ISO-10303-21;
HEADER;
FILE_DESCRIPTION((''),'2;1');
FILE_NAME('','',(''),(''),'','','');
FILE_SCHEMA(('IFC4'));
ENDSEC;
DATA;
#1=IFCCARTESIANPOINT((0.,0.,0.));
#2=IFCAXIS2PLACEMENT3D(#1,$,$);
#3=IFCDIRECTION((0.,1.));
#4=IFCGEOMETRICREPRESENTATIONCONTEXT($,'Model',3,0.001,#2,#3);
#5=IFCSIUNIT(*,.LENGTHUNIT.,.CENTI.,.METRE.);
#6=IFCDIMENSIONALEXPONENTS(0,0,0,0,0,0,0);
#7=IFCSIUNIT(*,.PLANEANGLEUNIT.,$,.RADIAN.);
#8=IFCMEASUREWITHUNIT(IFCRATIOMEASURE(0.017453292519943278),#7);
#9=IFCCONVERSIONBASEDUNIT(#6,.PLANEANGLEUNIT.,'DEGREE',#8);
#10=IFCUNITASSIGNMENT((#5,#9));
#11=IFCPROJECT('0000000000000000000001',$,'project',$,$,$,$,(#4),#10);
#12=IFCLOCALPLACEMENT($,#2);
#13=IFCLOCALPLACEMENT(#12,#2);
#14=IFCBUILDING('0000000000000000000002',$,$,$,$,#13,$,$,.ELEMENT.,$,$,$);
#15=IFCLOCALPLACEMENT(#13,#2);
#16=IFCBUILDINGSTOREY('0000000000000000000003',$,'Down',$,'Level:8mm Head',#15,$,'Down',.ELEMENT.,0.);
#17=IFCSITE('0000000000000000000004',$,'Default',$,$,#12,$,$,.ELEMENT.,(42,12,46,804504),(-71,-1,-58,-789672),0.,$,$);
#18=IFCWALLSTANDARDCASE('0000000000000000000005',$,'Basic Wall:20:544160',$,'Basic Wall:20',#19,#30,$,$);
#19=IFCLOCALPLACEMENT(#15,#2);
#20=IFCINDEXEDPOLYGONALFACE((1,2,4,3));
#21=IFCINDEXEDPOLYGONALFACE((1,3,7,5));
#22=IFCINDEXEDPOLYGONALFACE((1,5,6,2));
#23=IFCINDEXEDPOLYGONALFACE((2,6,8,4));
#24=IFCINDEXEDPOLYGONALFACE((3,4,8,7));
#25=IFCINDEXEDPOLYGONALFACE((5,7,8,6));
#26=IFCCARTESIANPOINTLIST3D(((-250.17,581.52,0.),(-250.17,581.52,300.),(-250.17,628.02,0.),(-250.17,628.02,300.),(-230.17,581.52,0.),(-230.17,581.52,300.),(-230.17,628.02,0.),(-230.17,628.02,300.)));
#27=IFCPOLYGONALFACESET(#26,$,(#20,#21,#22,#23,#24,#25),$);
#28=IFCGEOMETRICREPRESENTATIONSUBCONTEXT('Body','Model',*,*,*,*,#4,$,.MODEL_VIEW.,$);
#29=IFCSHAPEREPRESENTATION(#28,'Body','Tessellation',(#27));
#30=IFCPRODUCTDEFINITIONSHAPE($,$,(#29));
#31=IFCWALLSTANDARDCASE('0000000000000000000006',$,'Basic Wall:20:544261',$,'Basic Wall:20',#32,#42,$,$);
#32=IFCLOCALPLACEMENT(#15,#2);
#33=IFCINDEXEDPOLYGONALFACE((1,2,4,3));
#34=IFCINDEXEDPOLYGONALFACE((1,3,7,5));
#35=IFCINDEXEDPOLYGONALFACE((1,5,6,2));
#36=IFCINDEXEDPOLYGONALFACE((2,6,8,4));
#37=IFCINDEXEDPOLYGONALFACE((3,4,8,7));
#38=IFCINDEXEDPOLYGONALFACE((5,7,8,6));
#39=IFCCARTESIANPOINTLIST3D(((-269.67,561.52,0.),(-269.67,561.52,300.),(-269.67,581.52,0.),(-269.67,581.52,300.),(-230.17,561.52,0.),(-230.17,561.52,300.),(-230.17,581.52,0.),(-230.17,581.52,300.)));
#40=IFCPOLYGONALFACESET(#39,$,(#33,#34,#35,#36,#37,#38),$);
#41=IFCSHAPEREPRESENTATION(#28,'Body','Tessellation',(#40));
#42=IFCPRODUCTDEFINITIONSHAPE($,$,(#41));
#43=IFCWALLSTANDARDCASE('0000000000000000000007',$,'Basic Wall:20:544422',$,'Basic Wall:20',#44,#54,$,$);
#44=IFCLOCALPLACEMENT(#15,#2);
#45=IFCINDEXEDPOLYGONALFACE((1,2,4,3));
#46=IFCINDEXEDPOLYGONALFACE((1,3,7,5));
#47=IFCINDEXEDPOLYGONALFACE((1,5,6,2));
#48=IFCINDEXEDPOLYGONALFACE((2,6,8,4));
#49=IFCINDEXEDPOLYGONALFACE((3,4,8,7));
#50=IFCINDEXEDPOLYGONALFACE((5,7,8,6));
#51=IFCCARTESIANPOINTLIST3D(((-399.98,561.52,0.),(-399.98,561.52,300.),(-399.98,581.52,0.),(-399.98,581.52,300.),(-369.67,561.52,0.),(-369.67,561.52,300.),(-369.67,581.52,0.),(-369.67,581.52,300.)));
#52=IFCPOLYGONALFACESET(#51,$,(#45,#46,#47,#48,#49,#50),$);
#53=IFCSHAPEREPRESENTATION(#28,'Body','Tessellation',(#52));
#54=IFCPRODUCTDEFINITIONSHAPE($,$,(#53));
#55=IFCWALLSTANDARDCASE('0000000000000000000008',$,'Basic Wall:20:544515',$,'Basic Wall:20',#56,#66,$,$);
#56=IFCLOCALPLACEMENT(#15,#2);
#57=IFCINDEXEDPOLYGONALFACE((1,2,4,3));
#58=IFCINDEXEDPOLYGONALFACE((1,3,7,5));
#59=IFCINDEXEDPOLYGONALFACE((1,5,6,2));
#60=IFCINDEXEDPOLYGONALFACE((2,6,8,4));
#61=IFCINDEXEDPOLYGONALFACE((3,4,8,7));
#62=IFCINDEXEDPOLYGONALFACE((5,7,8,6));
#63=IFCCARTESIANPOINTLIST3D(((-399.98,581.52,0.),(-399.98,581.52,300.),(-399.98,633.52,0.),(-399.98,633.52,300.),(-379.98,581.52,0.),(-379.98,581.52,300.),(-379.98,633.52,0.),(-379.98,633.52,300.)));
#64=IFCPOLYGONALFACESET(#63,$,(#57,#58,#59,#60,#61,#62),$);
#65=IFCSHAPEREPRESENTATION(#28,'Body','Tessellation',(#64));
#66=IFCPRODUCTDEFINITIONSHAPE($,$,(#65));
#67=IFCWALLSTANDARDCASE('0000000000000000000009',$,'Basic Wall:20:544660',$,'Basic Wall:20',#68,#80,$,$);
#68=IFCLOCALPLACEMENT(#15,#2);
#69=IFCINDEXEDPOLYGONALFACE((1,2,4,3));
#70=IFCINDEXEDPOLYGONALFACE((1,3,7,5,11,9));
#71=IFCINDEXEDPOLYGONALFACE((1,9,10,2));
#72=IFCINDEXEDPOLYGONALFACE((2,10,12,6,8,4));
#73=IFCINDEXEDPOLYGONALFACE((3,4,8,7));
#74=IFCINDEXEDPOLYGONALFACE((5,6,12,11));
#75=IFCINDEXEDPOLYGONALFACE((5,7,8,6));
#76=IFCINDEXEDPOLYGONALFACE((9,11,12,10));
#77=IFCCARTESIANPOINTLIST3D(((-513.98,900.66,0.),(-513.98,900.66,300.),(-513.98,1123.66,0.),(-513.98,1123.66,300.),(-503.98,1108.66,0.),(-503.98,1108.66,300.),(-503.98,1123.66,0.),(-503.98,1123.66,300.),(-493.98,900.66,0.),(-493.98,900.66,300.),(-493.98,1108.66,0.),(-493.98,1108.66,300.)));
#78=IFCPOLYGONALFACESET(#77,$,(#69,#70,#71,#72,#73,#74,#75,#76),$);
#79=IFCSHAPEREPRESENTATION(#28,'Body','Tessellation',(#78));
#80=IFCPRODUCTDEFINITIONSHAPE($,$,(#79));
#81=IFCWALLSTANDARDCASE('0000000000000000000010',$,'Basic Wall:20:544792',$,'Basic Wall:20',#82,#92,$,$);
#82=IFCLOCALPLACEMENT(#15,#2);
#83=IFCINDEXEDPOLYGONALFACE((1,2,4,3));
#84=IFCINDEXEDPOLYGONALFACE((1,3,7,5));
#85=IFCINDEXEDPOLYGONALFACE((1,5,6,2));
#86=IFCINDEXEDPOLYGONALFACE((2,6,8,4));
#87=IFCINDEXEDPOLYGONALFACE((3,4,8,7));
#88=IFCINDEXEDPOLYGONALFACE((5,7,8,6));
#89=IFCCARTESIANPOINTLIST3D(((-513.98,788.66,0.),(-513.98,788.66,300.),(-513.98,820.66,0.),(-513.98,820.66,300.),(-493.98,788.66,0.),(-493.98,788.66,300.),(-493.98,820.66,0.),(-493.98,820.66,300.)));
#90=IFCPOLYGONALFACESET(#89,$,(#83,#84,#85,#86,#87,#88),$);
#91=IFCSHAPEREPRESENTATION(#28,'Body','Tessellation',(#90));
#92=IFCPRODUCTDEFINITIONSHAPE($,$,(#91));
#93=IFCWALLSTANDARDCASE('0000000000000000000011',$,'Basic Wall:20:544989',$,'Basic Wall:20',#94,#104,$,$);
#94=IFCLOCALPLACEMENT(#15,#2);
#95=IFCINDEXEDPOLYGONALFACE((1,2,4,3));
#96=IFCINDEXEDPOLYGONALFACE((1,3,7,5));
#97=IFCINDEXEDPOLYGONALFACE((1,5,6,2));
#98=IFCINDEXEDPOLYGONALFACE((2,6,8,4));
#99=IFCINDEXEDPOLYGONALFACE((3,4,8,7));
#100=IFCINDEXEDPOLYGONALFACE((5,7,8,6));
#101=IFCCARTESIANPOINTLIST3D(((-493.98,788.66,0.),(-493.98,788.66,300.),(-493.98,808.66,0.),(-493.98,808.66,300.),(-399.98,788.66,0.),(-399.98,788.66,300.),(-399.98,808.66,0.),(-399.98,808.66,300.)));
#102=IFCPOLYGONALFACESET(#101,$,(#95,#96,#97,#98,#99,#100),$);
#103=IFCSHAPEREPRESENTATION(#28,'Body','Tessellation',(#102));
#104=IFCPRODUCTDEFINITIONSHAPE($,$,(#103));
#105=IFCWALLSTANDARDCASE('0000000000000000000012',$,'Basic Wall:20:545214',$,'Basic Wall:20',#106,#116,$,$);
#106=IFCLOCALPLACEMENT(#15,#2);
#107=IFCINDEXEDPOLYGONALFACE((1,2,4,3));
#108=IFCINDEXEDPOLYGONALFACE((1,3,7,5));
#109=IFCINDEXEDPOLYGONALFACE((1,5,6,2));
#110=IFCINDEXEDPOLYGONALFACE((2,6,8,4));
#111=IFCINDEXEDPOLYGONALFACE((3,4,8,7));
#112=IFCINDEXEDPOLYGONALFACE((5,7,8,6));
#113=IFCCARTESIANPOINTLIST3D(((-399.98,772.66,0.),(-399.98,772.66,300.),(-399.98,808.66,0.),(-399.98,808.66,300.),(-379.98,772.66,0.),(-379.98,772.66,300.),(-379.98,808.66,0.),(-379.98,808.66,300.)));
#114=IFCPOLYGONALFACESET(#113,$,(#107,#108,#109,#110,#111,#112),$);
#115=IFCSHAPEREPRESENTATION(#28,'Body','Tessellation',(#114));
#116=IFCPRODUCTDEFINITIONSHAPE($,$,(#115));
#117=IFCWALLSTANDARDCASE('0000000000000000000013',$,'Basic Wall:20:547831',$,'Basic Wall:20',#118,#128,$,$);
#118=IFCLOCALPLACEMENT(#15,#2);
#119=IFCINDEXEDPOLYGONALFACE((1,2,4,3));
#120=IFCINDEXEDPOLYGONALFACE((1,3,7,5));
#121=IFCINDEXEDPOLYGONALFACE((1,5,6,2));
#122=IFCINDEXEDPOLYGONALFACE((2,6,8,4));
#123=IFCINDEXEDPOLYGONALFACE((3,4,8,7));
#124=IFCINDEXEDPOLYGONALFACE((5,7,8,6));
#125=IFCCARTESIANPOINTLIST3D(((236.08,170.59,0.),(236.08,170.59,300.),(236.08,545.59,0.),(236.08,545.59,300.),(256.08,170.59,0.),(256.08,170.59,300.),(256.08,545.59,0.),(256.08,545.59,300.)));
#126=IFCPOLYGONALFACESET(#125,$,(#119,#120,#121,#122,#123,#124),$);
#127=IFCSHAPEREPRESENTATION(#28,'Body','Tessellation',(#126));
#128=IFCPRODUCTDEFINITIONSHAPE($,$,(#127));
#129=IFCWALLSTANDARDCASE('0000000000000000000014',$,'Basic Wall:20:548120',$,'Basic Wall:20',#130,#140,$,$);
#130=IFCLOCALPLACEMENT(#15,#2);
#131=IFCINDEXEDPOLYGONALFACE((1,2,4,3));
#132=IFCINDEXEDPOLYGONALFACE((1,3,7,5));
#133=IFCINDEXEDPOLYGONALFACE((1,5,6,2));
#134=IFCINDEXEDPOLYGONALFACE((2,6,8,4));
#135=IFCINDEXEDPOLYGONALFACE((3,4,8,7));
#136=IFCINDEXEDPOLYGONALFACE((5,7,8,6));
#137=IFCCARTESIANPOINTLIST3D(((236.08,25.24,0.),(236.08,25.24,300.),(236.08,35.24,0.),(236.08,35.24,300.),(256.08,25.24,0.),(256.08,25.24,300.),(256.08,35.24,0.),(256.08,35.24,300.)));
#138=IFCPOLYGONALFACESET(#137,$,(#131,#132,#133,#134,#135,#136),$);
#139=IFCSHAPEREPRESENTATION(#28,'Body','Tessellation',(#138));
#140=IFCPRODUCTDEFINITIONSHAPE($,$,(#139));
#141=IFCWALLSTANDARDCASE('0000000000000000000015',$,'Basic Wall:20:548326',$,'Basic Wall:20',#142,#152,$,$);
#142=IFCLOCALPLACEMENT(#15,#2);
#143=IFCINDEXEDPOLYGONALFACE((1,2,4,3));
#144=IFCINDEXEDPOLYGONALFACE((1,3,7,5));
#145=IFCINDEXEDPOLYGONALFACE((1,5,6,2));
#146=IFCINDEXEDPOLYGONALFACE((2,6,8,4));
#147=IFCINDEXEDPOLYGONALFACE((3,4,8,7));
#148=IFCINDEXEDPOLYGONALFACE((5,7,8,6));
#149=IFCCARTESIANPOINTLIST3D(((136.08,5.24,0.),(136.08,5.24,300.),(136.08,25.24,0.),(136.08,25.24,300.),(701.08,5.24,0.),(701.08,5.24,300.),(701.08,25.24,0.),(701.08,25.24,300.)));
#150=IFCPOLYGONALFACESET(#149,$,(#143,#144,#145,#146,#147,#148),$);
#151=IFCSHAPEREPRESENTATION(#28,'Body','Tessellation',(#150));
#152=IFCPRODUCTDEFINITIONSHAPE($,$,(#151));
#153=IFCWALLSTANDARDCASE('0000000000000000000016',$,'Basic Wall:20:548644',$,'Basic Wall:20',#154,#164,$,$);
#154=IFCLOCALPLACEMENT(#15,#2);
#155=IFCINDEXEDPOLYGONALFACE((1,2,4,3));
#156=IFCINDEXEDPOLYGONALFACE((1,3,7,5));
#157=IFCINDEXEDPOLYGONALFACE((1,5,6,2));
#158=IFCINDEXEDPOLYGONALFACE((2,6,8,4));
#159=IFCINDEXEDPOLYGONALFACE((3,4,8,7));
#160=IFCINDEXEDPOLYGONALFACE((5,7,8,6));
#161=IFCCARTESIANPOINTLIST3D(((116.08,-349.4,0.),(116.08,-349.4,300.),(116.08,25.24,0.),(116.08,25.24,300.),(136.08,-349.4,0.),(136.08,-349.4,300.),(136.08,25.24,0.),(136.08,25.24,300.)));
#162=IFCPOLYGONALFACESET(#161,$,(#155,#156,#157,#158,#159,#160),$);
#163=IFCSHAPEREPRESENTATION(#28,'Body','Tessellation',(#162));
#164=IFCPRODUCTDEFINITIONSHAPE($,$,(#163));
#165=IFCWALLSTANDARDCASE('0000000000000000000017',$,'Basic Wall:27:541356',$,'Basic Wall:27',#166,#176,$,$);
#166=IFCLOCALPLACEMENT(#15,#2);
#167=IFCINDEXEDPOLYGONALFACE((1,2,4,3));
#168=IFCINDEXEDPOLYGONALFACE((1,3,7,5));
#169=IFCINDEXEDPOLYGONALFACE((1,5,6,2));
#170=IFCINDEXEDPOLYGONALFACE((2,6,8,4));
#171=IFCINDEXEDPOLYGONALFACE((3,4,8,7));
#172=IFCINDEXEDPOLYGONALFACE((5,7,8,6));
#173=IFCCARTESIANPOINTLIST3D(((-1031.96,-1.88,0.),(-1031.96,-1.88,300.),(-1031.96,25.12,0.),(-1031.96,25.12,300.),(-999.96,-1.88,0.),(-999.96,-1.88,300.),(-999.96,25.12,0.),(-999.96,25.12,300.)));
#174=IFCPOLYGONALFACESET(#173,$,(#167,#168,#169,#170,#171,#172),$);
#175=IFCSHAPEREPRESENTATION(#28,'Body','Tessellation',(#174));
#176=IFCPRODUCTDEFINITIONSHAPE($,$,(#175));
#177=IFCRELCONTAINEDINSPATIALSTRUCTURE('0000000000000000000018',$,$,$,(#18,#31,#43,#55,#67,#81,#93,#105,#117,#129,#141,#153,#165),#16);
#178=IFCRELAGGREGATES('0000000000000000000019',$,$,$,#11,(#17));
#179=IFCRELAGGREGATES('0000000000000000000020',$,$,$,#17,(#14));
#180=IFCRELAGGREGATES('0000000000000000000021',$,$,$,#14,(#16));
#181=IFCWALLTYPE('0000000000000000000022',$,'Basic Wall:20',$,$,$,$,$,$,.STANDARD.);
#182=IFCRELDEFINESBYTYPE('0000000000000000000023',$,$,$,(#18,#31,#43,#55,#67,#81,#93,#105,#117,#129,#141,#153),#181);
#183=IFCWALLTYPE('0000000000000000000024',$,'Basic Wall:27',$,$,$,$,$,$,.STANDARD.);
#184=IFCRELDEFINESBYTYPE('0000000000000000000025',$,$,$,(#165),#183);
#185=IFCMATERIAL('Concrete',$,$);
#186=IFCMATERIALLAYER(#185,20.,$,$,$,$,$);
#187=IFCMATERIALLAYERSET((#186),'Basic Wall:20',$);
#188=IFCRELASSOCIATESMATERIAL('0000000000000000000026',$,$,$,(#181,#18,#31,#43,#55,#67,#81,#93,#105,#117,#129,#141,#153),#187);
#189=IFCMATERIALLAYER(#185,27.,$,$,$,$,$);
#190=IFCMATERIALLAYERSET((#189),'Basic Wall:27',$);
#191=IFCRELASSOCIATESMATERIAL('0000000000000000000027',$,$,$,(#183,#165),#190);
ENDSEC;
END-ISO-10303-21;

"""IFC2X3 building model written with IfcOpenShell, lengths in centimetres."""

from ifc_helpers import new_model, entity, si_unit, converted_unit, direction, frame, frame_2d, origin, place, context, subcontext, project, spatial, polyline, rectangle, outline, extrude, material, layer, layer_set, layer_usage, type_object, element, save


model = new_model("IFC2X3")

# Units and contexts
model_context = context("Model", 3, precision=0.001, world=origin(), true_north=direction((0.0, 1.0)))
body_context = subcontext(model_context, "Body", "Model", "MODEL_VIEW")
ifc_project = project(units=[si_unit("LENGTHUNIT", "METRE", prefix="CENTI"), converted_unit("PLANEANGLEUNIT", "DEGREE", entity("IfcRatioMeasure", 0.017453292519943278), si_unit("PLANEANGLEUNIT", "RADIAN"), dimensions=[0, 0, 0, 0, 0, 0, 0])], contexts=[model_context])

# Site, building, storey
site_placement = place(None, origin())
site = spatial("IfcSite", under=ifc_project, at=site_placement, Name="Default", CompositionType="ELEMENT", RefLatitude=(42, 12, 46, 804504), RefLongitude=(-71, -1, -58, -789672), RefElevation=0.0)
building_placement = place(site_placement, origin())
building = spatial("IfcBuilding", under=site, at=building_placement, CompositionType="ELEMENT")
storey_placement = place(building_placement, origin())
storey = spatial("IfcBuildingStorey", under=building, at=storey_placement, Name="Down", ObjectType="Level:8mm Head", LongName="Down", CompositionType="ELEMENT", Elevation=0.0)

# Walls
ifc_material = material(Name="Concrete")
ifc_layer_1 = layer(ifc_material, 20.0)
ifc_layer_set_1 = layer_set([ifc_layer_1], Name="Basic Wall:20")
wall_type_1 = type_object("IfcWallType", Name="Basic Wall:20", PredefinedType="STANDARD", material=ifc_layer_set_1)
ifc_layer_usage_1 = layer_usage(ifc_layer_set_1, "AXIS2", "POSITIVE", -10.0)
wall_1_placement = place(storey_placement, frame((-240.17, 628.02, 0.0), z_axis=(0.0, 0.0, 1.0), x_axis=(0.0, -1.0, 0.0)))
element("IfcWallStandardCase", 1, at=wall_1_placement, inside=storey, type_object=wall_type_1, material=ifc_layer_usage_1, Name="Basic Wall:20:544160", ObjectType="Basic Wall:20", context=body_context, shape_type="SweptSolid", body=[
    extrude(rectangle(XDim=46.5, YDim=20.0, at=frame_2d((23.25, 0.0), x_axis=(-1.0, 0.0))), origin(), (0.0, 0.0, 1.0), 300.0),
])
ifc_layer_usage_2 = layer_usage(ifc_layer_set_1, "AXIS2", "NEGATIVE", 10.0)
wall_2_placement = place(storey_placement, frame((-230.17, 571.52, 0.0), z_axis=(0.0, 0.0, 1.0), x_axis=(-1.0, 0.0, 0.0)))
element("IfcWallStandardCase", 2, at=wall_2_placement, inside=storey, type_object=wall_type_1, material=ifc_layer_usage_2, Name="Basic Wall:20:544261", ObjectType="Basic Wall:20", context=body_context, shape_type="SweptSolid", body=[
    extrude(rectangle(XDim=39.5, YDim=20.0, at=frame_2d((19.75, 0.0), x_axis=(-1.0, 0.0))), origin(), (0.0, 0.0, 1.0), 300.0),
])
ifc_layer_usage_3 = layer_usage(ifc_layer_set_1, "AXIS2", "NEGATIVE", 10.0)
wall_3_placement = place(storey_placement, frame((-369.67, 571.52, 0.0), z_axis=(0.0, 0.0, 1.0), x_axis=(-1.0, 0.0, 0.0)))
element("IfcWallStandardCase", 3, at=wall_3_placement, inside=storey, type_object=wall_type_1, material=ifc_layer_usage_3, Name="Basic Wall:20:544422", ObjectType="Basic Wall:20", context=body_context, shape_type="SweptSolid", body=[
    extrude(rectangle(XDim=30.32, YDim=20.0, at=frame_2d((15.16, 0.0), x_axis=(-1.0, 0.0))), origin(), (0.0, 0.0, 1.0), 300.0),
])
ifc_layer_usage_4 = layer_usage(ifc_layer_set_1, "AXIS2", "NEGATIVE", 10.0)
wall_4_placement = place(storey_placement, frame((-389.98, 581.52, 0.0), z_axis=(0.0, 0.0, 1.0), x_axis=(0.0, 1.0, 0.0)))
element("IfcWallStandardCase", 4, at=wall_4_placement, inside=storey, type_object=wall_type_1, material=ifc_layer_usage_4, Name="Basic Wall:20:544515", ObjectType="Basic Wall:20", context=body_context, shape_type="SweptSolid", body=[
    extrude(rectangle(XDim=52.0, YDim=20.0, at=frame_2d((26.0, 0.0), x_axis=(-1.0, 0.0))), origin(), (0.0, 0.0, 1.0), 300.0),
])
ifc_layer_usage_5 = layer_usage(ifc_layer_set_1, "AXIS2", "POSITIVE", -10.0)
wall_5_placement = place(storey_placement, frame((-503.98, 1123.66, 0.0), z_axis=(0.0, 0.0, 1.0), x_axis=(0.0, -1.0, 0.0)))
element("IfcWallStandardCase", 5, at=wall_5_placement, inside=storey, type_object=wall_type_1, material=ifc_layer_usage_5, Name="Basic Wall:20:544660", ObjectType="Basic Wall:20", context=body_context, shape_type="SweptSolid", body=[
    extrude(outline(polyline([(223.0, -10.0), (223.0, 10.0), (15.0, 10.0), (15.0, 0.0), (0.0, 0.0), (0.0, -10.0), (223.0, -10.0)])), origin(), (0.0, 0.0, 1.0), 300.0),
])
ifc_layer_usage_6 = layer_usage(ifc_layer_set_1, "AXIS2", "POSITIVE", -10.0)
wall_6_placement = place(storey_placement, frame((-503.98, 820.66, 0.0), z_axis=(0.0, 0.0, 1.0), x_axis=(0.0, -1.0, 0.0)))
element("IfcWallStandardCase", 6, at=wall_6_placement, inside=storey, type_object=wall_type_1, material=ifc_layer_usage_6, Name="Basic Wall:20:544792", ObjectType="Basic Wall:20", context=body_context, shape_type="SweptSolid", body=[
    extrude(rectangle(XDim=32.0, YDim=20.0, at=frame_2d((16.0, 0.0), x_axis=(-1.0, 0.0))), origin(), (0.0, 0.0, 1.0), 300.0),
])
ifc_layer_usage_7 = layer_usage(ifc_layer_set_1, "AXIS2", "POSITIVE", -10.0)
wall_7_placement = place(storey_placement, frame((-493.98, 798.66, 0.0)))
element("IfcWallStandardCase", 7, at=wall_7_placement, inside=storey, type_object=wall_type_1, material=ifc_layer_usage_7, Name="Basic Wall:20:544989", ObjectType="Basic Wall:20", context=body_context, shape_type="SweptSolid", body=[
    extrude(rectangle(XDim=94.0, YDim=20.0, at=frame_2d((47.0, 0.0), x_axis=(-1.0, 0.0))), origin(), (0.0, 0.0, 1.0), 300.0),
])
ifc_layer_usage_8 = layer_usage(ifc_layer_set_1, "AXIS2", "POSITIVE", -10.0)
wall_8_placement = place(storey_placement, frame((-389.98, 808.66, 0.0), z_axis=(0.0, 0.0, 1.0), x_axis=(0.0, -1.0, 0.0)))
element("IfcWallStandardCase", 8, at=wall_8_placement, inside=storey, type_object=wall_type_1, material=ifc_layer_usage_8, Name="Basic Wall:20:545214", ObjectType="Basic Wall:20", context=body_context, shape_type="SweptSolid", body=[
    extrude(rectangle(XDim=36.0, YDim=20.0, at=frame_2d((18.0, 0.0), x_axis=(-1.0, 0.0))), origin(), (0.0, 0.0, 1.0), 300.0),
])
ifc_layer_usage_9 = layer_usage(ifc_layer_set_1, "AXIS2", "POSITIVE", -10.0)
wall_9_placement = place(storey_placement, frame((246.08, 545.59, 0.0), z_axis=(0.0, 0.0, 1.0), x_axis=(0.0, -1.0, 0.0)))
element("IfcWallStandardCase", 9, at=wall_9_placement, inside=storey, type_object=wall_type_1, material=ifc_layer_usage_9, Name="Basic Wall:20:547831", ObjectType="Basic Wall:20", context=body_context, shape_type="SweptSolid", body=[
    extrude(rectangle(XDim=375.0, YDim=20.0, at=frame_2d((187.5, 0.0), x_axis=(-1.0, 0.0))), origin(), (0.0, 0.0, 1.0), 300.0),
])
ifc_layer_usage_10 = layer_usage(ifc_layer_set_1, "AXIS2", "POSITIVE", -10.0)
wall_10_placement = place(storey_placement, frame((246.08, 35.24, 0.0), z_axis=(0.0, 0.0, 1.0), x_axis=(0.0, -1.0, 0.0)))
element("IfcWallStandardCase", 10, at=wall_10_placement, inside=storey, type_object=wall_type_1, material=ifc_layer_usage_10, Name="Basic Wall:20:548120", ObjectType="Basic Wall:20", context=body_context, shape_type="SweptSolid", body=[
    extrude(rectangle(XDim=10.0, YDim=20.0, at=frame_2d((5.0, 0.0), x_axis=(-1.0, 0.0))), origin(), (0.0, 0.0, 1.0), 300.0),
])
ifc_layer_usage_11 = layer_usage(ifc_layer_set_1, "AXIS2", "NEGATIVE", 10.0)
wall_11_placement = place(storey_placement, frame((136.08, 15.24, 0.0)))
element("IfcWallStandardCase", 11, at=wall_11_placement, inside=storey, type_object=wall_type_1, material=ifc_layer_usage_11, Name="Basic Wall:20:548326", ObjectType="Basic Wall:20", context=body_context, shape_type="SweptSolid", body=[
    extrude(rectangle(XDim=565.0, YDim=20.0, at=frame_2d((282.5, 0.0), x_axis=(-1.0, 0.0))), origin(), (0.0, 0.0, 1.0), 300.0),
])
ifc_layer_usage_12 = layer_usage(ifc_layer_set_1, "AXIS2", "POSITIVE", -10.0)
wall_12_placement = place(storey_placement, frame((126.08, 25.24, 0.0), z_axis=(0.0, 0.0, 1.0), x_axis=(0.0, -1.0, 0.0)))
element("IfcWallStandardCase", 12, at=wall_12_placement, inside=storey, type_object=wall_type_1, material=ifc_layer_usage_12, Name="Basic Wall:20:548644", ObjectType="Basic Wall:20", context=body_context, shape_type="SweptSolid", body=[
    extrude(rectangle(XDim=374.64, YDim=20.0, at=frame_2d((187.32, 0.0), x_axis=(-1.0, 0.0))), origin(), (0.0, 0.0, 1.0), 300.0),
])
ifc_layer_2 = layer(ifc_material, 27.0)
ifc_layer_set_2 = layer_set([ifc_layer_2], Name="Basic Wall:27")
ifc_layer_usage_13 = layer_usage(ifc_layer_set_2, "AXIS2", "POSITIVE", -13.5)
wall_type_2 = type_object("IfcWallType", Name="Basic Wall:27", PredefinedType="STANDARD", material=ifc_layer_set_2)
wall_13_placement = place(storey_placement, frame((-1031.96, 11.62, 0.0)))
element("IfcWallStandardCase", 13, at=wall_13_placement, inside=storey, type_object=wall_type_2, material=ifc_layer_usage_13, Name="Basic Wall:27:541356", ObjectType="Basic Wall:27", context=body_context, shape_type="SweptSolid", body=[
    extrude(rectangle(XDim=32.0, YDim=27.0, at=frame_2d((16.0, 0.0), x_axis=(-1.0, 0.0))), origin(), (0.0, 0.0, 1.0), 300.0),
])

save(model, "model.ifc")
